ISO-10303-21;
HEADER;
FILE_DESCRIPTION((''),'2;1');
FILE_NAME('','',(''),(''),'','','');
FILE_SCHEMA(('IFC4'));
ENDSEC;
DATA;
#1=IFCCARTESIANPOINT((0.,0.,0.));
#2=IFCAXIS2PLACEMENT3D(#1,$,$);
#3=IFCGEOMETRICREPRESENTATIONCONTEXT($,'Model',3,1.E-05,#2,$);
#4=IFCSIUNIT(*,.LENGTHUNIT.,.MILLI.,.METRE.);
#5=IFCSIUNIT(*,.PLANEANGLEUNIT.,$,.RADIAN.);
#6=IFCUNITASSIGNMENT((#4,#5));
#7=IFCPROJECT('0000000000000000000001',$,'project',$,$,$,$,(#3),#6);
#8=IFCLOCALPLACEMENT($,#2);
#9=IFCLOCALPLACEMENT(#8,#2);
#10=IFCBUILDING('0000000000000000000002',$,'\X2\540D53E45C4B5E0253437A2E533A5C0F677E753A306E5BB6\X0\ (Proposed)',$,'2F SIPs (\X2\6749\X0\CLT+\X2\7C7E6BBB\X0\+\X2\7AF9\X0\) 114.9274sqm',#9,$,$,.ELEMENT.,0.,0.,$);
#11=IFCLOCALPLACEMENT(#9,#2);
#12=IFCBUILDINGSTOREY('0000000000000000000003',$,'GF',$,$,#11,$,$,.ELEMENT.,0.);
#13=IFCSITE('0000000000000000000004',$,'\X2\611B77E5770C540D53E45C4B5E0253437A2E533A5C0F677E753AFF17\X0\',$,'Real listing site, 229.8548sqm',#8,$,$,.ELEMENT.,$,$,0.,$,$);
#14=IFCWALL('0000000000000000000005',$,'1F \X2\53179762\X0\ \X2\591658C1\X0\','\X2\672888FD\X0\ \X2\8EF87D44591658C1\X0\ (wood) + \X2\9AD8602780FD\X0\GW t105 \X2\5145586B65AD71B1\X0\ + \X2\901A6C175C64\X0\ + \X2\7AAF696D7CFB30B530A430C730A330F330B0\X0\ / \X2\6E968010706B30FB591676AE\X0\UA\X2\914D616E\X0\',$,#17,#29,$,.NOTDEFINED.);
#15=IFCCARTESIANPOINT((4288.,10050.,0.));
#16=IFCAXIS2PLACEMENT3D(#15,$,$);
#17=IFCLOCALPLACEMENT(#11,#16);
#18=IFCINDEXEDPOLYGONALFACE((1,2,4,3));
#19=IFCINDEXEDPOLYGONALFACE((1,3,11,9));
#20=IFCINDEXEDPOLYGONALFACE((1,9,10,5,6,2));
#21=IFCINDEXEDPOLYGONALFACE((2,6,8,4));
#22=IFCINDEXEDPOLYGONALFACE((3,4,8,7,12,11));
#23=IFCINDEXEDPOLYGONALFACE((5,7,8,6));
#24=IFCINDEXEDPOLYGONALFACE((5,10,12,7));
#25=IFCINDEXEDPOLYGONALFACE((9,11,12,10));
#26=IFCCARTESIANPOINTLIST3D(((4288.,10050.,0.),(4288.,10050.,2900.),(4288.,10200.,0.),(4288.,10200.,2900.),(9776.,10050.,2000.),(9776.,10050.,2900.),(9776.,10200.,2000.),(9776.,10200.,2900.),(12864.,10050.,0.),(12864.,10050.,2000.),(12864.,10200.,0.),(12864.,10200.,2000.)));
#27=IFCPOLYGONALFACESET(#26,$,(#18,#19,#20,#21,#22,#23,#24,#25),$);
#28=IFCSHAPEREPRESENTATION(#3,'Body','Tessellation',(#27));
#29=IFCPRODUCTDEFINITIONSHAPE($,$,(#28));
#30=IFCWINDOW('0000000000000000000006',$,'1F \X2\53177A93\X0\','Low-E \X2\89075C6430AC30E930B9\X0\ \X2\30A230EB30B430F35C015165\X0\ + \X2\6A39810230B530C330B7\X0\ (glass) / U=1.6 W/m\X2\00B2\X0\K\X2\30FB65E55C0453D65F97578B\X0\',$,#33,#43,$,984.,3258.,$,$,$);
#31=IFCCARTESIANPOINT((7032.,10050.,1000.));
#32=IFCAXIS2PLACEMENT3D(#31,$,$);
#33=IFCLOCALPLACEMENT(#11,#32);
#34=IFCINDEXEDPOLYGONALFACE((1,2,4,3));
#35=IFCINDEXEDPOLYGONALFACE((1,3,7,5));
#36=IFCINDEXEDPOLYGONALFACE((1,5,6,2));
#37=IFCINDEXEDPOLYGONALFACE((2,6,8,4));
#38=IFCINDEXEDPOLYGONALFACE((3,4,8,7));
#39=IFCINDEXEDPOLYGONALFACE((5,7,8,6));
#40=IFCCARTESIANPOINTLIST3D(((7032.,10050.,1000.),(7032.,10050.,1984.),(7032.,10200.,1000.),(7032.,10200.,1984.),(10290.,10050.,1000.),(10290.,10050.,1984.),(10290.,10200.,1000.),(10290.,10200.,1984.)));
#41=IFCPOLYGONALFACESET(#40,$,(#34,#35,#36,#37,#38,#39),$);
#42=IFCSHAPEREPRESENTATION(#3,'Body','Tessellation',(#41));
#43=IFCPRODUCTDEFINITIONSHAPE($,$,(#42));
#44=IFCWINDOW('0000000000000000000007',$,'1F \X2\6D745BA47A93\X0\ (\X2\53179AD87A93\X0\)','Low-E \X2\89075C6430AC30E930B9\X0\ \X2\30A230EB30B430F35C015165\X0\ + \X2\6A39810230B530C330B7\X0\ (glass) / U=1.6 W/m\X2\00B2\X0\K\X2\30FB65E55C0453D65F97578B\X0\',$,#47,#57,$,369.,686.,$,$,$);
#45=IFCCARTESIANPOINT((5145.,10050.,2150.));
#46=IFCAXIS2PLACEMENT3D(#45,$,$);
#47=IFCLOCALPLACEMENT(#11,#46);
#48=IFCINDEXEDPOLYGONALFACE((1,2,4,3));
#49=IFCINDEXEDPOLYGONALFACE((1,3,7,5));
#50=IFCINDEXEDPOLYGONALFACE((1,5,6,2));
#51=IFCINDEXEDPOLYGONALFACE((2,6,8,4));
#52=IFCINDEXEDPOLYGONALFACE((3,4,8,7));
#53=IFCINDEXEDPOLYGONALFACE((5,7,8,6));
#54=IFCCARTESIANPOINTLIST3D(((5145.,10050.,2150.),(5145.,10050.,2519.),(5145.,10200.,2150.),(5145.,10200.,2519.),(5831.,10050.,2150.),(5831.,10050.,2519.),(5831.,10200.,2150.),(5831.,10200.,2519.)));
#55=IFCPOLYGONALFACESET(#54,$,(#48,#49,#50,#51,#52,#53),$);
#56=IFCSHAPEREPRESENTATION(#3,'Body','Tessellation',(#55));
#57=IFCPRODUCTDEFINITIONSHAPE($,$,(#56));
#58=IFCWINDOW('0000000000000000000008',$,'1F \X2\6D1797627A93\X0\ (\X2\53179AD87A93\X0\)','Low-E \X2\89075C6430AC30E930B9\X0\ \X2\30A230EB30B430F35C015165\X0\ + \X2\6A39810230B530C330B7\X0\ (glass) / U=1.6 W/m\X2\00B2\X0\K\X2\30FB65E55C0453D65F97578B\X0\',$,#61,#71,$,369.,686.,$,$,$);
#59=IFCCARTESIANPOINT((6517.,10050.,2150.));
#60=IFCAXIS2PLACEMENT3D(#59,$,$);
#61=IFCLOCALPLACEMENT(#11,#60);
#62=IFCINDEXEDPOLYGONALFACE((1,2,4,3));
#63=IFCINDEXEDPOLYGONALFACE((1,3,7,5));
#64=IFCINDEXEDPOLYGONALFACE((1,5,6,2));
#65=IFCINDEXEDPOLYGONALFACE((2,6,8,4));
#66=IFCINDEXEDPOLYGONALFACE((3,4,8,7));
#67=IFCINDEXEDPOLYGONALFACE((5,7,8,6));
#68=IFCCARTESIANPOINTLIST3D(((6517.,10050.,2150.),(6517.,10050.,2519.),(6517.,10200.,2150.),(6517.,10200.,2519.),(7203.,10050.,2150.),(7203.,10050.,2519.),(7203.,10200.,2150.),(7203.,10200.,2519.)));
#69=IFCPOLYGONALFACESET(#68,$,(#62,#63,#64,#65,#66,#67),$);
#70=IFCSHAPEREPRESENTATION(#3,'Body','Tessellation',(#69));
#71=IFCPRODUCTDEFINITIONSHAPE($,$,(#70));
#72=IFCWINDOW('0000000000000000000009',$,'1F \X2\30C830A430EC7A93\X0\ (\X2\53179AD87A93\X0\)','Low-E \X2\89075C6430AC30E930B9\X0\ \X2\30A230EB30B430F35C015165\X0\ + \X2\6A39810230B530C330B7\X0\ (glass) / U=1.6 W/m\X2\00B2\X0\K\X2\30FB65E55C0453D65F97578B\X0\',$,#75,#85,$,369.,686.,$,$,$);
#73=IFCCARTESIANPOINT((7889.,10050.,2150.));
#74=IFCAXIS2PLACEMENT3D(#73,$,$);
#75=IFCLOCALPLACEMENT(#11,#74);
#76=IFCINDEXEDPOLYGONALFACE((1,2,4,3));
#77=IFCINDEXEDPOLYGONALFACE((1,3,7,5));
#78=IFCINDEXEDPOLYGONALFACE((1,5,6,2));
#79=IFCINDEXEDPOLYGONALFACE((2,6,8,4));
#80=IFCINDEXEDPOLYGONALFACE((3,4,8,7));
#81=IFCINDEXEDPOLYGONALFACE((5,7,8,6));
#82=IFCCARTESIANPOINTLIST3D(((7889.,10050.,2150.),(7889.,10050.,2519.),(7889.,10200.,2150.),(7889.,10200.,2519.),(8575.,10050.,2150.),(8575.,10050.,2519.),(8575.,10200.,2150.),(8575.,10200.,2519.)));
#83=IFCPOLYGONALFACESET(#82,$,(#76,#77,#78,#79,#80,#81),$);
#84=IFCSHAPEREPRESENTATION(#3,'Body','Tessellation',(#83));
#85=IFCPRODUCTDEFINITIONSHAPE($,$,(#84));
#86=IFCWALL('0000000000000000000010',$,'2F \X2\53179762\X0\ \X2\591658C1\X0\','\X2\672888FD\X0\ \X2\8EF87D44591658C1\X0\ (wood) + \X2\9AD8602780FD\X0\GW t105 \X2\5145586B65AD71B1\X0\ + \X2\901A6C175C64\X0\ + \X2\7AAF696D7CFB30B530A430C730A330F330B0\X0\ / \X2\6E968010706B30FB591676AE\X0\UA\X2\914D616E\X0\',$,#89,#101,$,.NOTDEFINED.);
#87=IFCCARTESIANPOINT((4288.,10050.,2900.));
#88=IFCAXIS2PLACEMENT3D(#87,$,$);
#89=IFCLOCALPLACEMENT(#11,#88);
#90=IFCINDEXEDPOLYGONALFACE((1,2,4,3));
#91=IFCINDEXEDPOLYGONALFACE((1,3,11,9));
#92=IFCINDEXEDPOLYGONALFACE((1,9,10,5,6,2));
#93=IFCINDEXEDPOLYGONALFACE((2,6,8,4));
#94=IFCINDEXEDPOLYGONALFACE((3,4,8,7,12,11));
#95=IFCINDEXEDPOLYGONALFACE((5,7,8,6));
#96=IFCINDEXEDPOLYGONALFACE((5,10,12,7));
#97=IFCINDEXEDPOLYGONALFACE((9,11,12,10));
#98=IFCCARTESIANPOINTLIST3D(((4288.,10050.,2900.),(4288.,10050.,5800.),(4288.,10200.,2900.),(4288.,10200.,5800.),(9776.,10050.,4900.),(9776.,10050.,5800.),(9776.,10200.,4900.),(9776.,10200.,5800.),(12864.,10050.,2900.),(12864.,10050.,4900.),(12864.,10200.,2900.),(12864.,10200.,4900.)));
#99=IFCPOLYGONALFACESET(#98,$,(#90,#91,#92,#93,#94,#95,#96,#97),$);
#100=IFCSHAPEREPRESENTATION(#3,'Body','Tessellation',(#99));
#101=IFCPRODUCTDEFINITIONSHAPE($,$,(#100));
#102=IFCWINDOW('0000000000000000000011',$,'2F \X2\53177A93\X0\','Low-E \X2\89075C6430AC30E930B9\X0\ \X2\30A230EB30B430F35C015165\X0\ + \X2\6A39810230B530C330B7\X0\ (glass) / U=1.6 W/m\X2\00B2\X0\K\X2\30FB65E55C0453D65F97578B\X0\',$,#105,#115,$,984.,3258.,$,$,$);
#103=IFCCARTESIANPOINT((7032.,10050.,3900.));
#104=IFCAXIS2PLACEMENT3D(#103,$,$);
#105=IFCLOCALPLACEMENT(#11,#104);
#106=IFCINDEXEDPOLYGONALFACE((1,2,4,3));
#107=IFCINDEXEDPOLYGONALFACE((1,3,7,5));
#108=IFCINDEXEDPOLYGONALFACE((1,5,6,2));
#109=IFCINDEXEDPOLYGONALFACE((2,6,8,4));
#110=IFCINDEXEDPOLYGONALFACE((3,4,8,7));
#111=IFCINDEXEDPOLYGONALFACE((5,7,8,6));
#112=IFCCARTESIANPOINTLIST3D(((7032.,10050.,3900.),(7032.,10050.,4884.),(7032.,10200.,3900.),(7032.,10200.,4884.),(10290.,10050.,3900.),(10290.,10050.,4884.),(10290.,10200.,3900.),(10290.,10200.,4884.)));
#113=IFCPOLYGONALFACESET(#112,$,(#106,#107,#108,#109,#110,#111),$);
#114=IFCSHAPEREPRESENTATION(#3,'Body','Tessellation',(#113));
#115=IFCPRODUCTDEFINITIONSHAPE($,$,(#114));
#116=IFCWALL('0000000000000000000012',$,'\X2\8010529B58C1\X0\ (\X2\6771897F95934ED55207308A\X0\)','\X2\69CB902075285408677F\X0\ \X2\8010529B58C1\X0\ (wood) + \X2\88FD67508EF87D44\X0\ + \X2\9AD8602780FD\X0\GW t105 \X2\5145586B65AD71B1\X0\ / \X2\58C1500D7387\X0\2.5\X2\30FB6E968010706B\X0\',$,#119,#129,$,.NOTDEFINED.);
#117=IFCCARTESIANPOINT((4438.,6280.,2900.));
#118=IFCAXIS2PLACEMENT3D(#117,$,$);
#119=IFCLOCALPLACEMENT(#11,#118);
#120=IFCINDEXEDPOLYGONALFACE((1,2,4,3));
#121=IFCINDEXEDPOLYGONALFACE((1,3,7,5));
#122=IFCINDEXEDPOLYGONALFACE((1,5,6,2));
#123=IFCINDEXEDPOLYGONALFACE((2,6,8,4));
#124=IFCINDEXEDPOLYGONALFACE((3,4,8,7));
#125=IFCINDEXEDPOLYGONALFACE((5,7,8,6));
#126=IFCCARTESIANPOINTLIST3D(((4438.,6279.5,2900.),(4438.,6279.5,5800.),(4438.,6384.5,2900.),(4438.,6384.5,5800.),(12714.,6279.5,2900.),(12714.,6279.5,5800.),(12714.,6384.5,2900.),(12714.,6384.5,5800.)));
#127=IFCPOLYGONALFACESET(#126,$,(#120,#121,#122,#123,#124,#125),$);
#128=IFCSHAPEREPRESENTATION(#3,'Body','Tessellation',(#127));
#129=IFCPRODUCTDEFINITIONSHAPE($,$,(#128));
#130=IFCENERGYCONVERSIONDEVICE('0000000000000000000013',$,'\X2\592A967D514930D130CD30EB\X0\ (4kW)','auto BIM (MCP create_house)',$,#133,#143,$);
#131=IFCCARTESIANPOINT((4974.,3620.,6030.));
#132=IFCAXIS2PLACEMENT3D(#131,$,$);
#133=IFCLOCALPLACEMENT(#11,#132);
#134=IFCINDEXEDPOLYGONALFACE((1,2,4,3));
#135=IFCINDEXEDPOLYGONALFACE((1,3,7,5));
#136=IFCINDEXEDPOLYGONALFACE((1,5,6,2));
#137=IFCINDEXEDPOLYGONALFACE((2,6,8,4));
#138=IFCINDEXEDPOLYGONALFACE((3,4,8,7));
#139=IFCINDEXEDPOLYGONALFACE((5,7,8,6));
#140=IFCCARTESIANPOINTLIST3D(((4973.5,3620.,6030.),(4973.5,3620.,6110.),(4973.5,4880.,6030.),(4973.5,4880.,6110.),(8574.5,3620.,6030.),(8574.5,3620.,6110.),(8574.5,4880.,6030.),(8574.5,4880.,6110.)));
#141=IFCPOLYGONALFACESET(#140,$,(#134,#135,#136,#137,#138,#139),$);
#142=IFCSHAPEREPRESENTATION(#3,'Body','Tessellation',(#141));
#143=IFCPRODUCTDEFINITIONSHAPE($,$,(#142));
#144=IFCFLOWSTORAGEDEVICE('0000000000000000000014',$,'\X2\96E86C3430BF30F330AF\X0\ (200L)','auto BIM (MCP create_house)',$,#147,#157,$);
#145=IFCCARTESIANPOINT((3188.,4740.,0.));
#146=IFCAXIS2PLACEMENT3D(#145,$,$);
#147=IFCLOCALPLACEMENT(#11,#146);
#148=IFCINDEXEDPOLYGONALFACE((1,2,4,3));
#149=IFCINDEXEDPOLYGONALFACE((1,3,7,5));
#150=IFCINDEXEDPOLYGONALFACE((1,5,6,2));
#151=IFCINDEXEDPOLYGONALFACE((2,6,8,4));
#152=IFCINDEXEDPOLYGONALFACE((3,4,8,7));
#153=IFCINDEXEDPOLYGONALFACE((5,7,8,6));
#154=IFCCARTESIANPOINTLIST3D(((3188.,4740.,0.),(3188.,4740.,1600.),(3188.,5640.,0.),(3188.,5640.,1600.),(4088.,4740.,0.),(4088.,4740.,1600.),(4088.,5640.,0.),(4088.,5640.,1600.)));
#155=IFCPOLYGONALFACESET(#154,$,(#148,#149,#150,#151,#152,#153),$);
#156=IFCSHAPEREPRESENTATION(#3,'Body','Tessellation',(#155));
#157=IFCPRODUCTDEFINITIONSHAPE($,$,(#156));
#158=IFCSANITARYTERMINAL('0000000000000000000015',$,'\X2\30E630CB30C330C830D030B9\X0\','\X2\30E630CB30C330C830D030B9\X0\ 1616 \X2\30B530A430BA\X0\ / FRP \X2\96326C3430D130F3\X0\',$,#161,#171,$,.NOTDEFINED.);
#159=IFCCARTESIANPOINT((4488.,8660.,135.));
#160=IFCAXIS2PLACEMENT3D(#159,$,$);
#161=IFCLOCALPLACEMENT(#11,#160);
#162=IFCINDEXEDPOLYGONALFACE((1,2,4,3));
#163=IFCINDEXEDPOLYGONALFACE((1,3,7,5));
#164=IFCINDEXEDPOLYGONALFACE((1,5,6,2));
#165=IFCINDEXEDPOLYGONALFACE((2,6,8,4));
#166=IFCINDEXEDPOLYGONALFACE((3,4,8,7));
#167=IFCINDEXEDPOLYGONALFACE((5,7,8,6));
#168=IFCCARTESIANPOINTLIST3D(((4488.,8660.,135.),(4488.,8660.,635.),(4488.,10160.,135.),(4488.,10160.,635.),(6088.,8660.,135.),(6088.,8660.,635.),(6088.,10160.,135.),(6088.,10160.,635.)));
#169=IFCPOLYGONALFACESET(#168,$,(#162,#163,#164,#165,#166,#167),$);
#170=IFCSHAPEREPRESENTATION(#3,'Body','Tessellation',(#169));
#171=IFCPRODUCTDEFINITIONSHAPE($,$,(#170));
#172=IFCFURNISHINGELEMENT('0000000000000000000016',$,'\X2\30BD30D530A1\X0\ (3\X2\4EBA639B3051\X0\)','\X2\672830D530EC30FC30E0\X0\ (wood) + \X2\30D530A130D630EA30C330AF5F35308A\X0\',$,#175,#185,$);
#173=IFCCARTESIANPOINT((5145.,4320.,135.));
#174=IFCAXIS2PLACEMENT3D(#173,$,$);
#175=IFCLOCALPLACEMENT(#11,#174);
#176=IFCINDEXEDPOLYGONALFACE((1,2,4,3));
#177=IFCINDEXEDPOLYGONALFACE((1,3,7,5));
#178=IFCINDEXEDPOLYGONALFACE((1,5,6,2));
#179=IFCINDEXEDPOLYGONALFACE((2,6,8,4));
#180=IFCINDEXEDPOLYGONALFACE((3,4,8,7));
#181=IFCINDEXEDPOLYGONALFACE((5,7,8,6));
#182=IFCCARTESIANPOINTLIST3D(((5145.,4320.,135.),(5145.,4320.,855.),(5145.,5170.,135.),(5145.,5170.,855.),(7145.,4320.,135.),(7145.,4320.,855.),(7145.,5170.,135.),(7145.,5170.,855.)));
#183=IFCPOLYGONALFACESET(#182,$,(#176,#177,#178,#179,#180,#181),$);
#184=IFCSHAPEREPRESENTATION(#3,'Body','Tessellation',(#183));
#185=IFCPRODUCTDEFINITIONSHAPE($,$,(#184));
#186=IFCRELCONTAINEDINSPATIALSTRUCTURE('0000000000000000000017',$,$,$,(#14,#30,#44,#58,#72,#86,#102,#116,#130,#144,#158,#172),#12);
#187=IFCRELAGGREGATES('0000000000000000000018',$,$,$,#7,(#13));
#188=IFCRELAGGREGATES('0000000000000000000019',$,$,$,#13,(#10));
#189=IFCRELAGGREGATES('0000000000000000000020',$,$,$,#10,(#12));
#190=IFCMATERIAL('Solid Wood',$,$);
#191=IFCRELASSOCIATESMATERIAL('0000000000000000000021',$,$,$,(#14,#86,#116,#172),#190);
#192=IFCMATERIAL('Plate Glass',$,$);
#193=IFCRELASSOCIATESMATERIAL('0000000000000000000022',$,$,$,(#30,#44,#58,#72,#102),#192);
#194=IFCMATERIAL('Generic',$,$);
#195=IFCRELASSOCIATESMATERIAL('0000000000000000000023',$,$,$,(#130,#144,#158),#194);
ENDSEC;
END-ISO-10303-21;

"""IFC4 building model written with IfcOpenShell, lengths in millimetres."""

from ifc_helpers import new_model, si_unit, frame, frame_2d, origin, place, context, project, spatial, rectangle, extrude, material, element, fill, save


model = new_model("IFC4")

# Units and contexts
model_context = context("Model", 3, precision=1e-05, world=origin())
ifc_project = project(units=[si_unit("LENGTHUNIT", "METRE", prefix="MILLI"), si_unit("PLANEANGLEUNIT", "RADIAN")], contexts=[model_context])

# Site, building, storey
site_placement = place(None, origin())
site = spatial("IfcSite", under=ifc_project, at=site_placement, Name="愛知県名古屋市千種区小松町７", ObjectType="Real listing site, 229.8548sqm", CompositionType="ELEMENT", RefElevation=0.0)
building_placement = place(site_placement, origin())
building = spatial("IfcBuilding", under=site, at=building_placement, Name="名古屋市千種区小松町の家 (Proposed)", ObjectType="2F SIPs (杉CLT+籾殻+竹) 114.9274sqm", CompositionType="ELEMENT", ElevationOfRefHeight=0.0, ElevationOfTerrain=0.0)
storey_placement = place(building_placement, origin())
storey = spatial("IfcBuildingStorey", under=building, at=storey_placement, Name="GF", CompositionType="ELEMENT", Elevation=0.0)

# Wall, openings, windows
ifc_material_1 = material(Name="Solid Wood")
wall_1_placement = place(storey_placement, frame((4288.0, 10050.0, 0.0)))
wall_1 = element("IfcWall", 1, at=wall_1_placement, inside=storey, material=ifc_material_1, Name="1F 北面 外壁", Description="木製 軸組外壁 (wood) + 高性能GW t105 充填断熱 + 通気層 + 窯業系サイディング / 準耐火・外皮UA配慮", PredefinedType="NOTDEFINED", context=model_context, shape_type="SweptSolid", body=[
    extrude(rectangle(XDim=8576.0, YDim=150.0, at=frame_2d((4288.0, 75.0))), frame((4288.0, 10050.0, 0.0)), (0.0, 0.0, 1.0), 2900.0),
])
opening_1_placement = place(storey_placement, frame((7032.0, 10050.0, 1000.0)))
opening_1 = element("IfcOpeningElement", 2, at=opening_1_placement, cuts=wall_1, PredefinedType="NOTDEFINED", context=model_context, shape_type="SweptSolid", body=[
    extrude(rectangle(XDim=3258.0, YDim=150.0, at=frame_2d((1629.0, 75.0))), frame((7032.0, 10050.0, 1000.0)), (0.0, 0.0, 1.0), 984.0),
])
opening_2_placement = place(storey_placement, frame((5145.0, 10050.0, 2150.0)))
opening_2 = element("IfcOpeningElement", 3, at=opening_2_placement, cuts=wall_1, PredefinedType="NOTDEFINED", context=model_context, shape_type="SweptSolid", body=[
    extrude(rectangle(XDim=686.0, YDim=150.0, at=frame_2d((343.0, 75.0))), frame((5145.0, 10050.0, 2150.0)), (0.0, 0.0, 1.0), 369.0),
])
opening_3_placement = place(storey_placement, frame((6517.0, 10050.0, 2150.0)))
opening_3 = element("IfcOpeningElement", 4, at=opening_3_placement, cuts=wall_1, PredefinedType="NOTDEFINED", context=model_context, shape_type="SweptSolid", body=[
    extrude(rectangle(XDim=686.0, YDim=150.0, at=frame_2d((343.0, 75.0))), frame((6517.0, 10050.0, 2150.0)), (0.0, 0.0, 1.0), 369.0),
])
opening_4_placement = place(storey_placement, frame((7889.0, 10050.0, 2150.0)))
opening_4 = element("IfcOpeningElement", 5, at=opening_4_placement, cuts=wall_1, PredefinedType="NOTDEFINED", context=model_context, shape_type="SweptSolid", body=[
    extrude(rectangle(XDim=686.0, YDim=150.0, at=frame_2d((343.0, 75.0))), frame((7889.0, 10050.0, 2150.0)), (0.0, 0.0, 1.0), 369.0),
])
ifc_material_2 = material(Name="Plate Glass")
window_1_placement = place(storey_placement, frame((7032.0, 10050.0, 1000.0)))
window_1 = element("IfcWindow", 6, at=window_1_placement, inside=storey, material=ifc_material_2, Name="1F 北窓", Description="Low-E 複層ガラス アルゴン封入 + 樹脂サッシ (glass) / U=1.6 W/m²K・日射取得型", OverallHeight=984.0, OverallWidth=3258.0, context=model_context, shape_type="SweptSolid", body=[
    extrude(rectangle(XDim=3258.0, YDim=150.0, at=frame_2d((1629.0, 75.0))), frame((7032.0, 10050.0, 1000.0)), (0.0, 0.0, 1.0), 984.0),
])
fill(opening_1, window_1)
window_2_placement = place(storey_placement, frame((5145.0, 10050.0, 2150.0)))
window_2 = element("IfcWindow", 7, at=window_2_placement, inside=storey, material=ifc_material_2, Name="1F 浴室窓 (北高窓)", Description="Low-E 複層ガラス アルゴン封入 + 樹脂サッシ (glass) / U=1.6 W/m²K・日射取得型", OverallHeight=369.0, OverallWidth=686.0, context=model_context, shape_type="SweptSolid", body=[
    extrude(rectangle(XDim=686.0, YDim=150.0, at=frame_2d((343.0, 75.0))), frame((5145.0, 10050.0, 2150.0)), (0.0, 0.0, 1.0), 369.0),
])
fill(opening_2, window_2)
window_3_placement = place(storey_placement, frame((6517.0, 10050.0, 2150.0)))
window_3 = element("IfcWindow", 8, at=window_3_placement, inside=storey, material=ifc_material_2, Name="1F 洗面窓 (北高窓)", Description="Low-E 複層ガラス アルゴン封入 + 樹脂サッシ (glass) / U=1.6 W/m²K・日射取得型", OverallHeight=369.0, OverallWidth=686.0, context=model_context, shape_type="SweptSolid", body=[
    extrude(rectangle(XDim=686.0, YDim=150.0, at=frame_2d((343.0, 75.0))), frame((6517.0, 10050.0, 2150.0)), (0.0, 0.0, 1.0), 369.0),
])
fill(opening_3, window_3)
window_4_placement = place(storey_placement, frame((7889.0, 10050.0, 2150.0)))
window_4 = element("IfcWindow", 9, at=window_4_placement, inside=storey, material=ifc_material_2, Name="1F トイレ窓 (北高窓)", Description="Low-E 複層ガラス アルゴン封入 + 樹脂サッシ (glass) / U=1.6 W/m²K・日射取得型", OverallHeight=369.0, OverallWidth=686.0, context=model_context, shape_type="SweptSolid", body=[
    extrude(rectangle(XDim=686.0, YDim=150.0, at=frame_2d((343.0, 75.0))), frame((7889.0, 10050.0, 2150.0)), (0.0, 0.0, 1.0), 369.0),
])
fill(opening_4, window_4)

# Wall, opening, window
wall_2_placement = place(storey_placement, frame((4288.0, 10050.0, 2900.0)))
wall_2 = element("IfcWall", 10, at=wall_2_placement, inside=storey, material=ifc_material_1, Name="2F 北面 外壁", Description="木製 軸組外壁 (wood) + 高性能GW t105 充填断熱 + 通気層 + 窯業系サイディング / 準耐火・外皮UA配慮", PredefinedType="NOTDEFINED", context=model_context, shape_type="SweptSolid", body=[
    extrude(rectangle(XDim=8576.0, YDim=150.0, at=frame_2d((4288.0, 75.0))), frame((4288.0, 10050.0, 2900.0)), (0.0, 0.0, 1.0), 2900.0),
])
opening_5_placement = place(storey_placement, frame((7032.0, 10050.0, 3900.0)))
opening_5 = element("IfcOpeningElement", 11, at=opening_5_placement, cuts=wall_2, PredefinedType="NOTDEFINED", context=model_context, shape_type="SweptSolid", body=[
    extrude(rectangle(XDim=3258.0, YDim=150.0, at=frame_2d((1629.0, 75.0))), frame((7032.0, 10050.0, 3900.0)), (0.0, 0.0, 1.0), 984.0),
])
window_5_placement = place(storey_placement, frame((7032.0, 10050.0, 3900.0)))
window_5 = element("IfcWindow", 12, at=window_5_placement, inside=storey, material=ifc_material_2, Name="2F 北窓", Description="Low-E 複層ガラス アルゴン封入 + 樹脂サッシ (glass) / U=1.6 W/m²K・日射取得型", OverallHeight=984.0, OverallWidth=3258.0, context=model_context, shape_type="SweptSolid", body=[
    extrude(rectangle(XDim=3258.0, YDim=150.0, at=frame_2d((1629.0, 75.0))), frame((7032.0, 10050.0, 3900.0)), (0.0, 0.0, 1.0), 984.0),
])
fill(opening_5, window_5)

# Wall
wall_3_placement = place(storey_placement, frame((4438.0, 6280.0, 2900.0)))
element("IfcWall", 13, at=wall_3_placement, inside=storey, material=ifc_material_1, Name="耐力壁 (東西間仕切り)", Description="構造用合板 耐力壁 (wood) + 製材軸組 + 高性能GW t105 充填断熱 / 壁倍率2.5・準耐火", PredefinedType="NOTDEFINED", context=model_context, shape_type="SweptSolid", body=[
    extrude(rectangle(XDim=8276.0, YDim=105.0, at=frame_2d((4138.0, 52.0))), frame((4438.0, 6280.0, 2900.0)), (0.0, 0.0, 1.0), 2900.0),
])

# Energy conversion device
ifc_material_3 = material(Name="Generic")
energy_conversion_device_placement = place(storey_placement, frame((4974.0, 3620.0, 6030.0)))
element("IfcEnergyConversionDevice", 14, at=energy_conversion_device_placement, inside=storey, material=ifc_material_3, Name="太陽光パネル (4kW)", Description="auto BIM (MCP create_house)", context=model_context, shape_type="SweptSolid", body=[
    extrude(rectangle(XDim=3601.0, YDim=1260.0, at=frame_2d((1800.0, 630.0))), frame((4974.0, 3620.0, 6030.0)), (0.0, 0.0, 1.0), 80.0),
])

# Flow storage device
flow_storage_device_placement = place(storey_placement, frame((3188.0, 4740.0, 0.0)))
element("IfcFlowStorageDevice", 15, at=flow_storage_device_placement, inside=storey, material=ifc_material_3, Name="雨水タンク (200L)", Description="auto BIM (MCP create_house)", context=model_context, shape_type="SweptSolid", body=[
    extrude(rectangle(XDim=900.0, YDim=900.0, at=frame_2d((450.0, 450.0))), frame((3188.0, 4740.0, 0.0)), (0.0, 0.0, 1.0), 1600.0),
])

# Sanitary terminal
sanitary_terminal_placement = place(storey_placement, frame((4488.0, 8660.0, 135.0)))
element("IfcSanitaryTerminal", 16, at=sanitary_terminal_placement, inside=storey, material=ifc_material_3, Name="ユニットバス", Description="ユニットバス 1616 サイズ / FRP 防水パン", PredefinedType="NOTDEFINED", context=model_context, shape_type="SweptSolid", body=[
    extrude(rectangle(XDim=1600.0, YDim=1500.0, at=frame_2d((800.0, 750.0))), frame((4488.0, 8660.0, 135.0)), (0.0, 0.0, 1.0), 500.0),
])

# Furnishing element
furnishing_1_placement = place(storey_placement, frame((5145.0, 4320.0, 135.0)))
element("IfcFurnishingElement", 17, at=furnishing_1_placement, inside=storey, material=ifc_material_1, Name="ソファ (3人掛け)", Description="木フレーム (wood) + ファブリック張り", context=model_context, shape_type="SweptSolid", body=[
    extrude(rectangle(XDim=2000.0, YDim=850.0, at=frame_2d((1000.0, 425.0))), frame((5145.0, 4320.0, 135.0)), (0.0, 0.0, 1.0), 720.0),
])

save(model, "model.ifc")
